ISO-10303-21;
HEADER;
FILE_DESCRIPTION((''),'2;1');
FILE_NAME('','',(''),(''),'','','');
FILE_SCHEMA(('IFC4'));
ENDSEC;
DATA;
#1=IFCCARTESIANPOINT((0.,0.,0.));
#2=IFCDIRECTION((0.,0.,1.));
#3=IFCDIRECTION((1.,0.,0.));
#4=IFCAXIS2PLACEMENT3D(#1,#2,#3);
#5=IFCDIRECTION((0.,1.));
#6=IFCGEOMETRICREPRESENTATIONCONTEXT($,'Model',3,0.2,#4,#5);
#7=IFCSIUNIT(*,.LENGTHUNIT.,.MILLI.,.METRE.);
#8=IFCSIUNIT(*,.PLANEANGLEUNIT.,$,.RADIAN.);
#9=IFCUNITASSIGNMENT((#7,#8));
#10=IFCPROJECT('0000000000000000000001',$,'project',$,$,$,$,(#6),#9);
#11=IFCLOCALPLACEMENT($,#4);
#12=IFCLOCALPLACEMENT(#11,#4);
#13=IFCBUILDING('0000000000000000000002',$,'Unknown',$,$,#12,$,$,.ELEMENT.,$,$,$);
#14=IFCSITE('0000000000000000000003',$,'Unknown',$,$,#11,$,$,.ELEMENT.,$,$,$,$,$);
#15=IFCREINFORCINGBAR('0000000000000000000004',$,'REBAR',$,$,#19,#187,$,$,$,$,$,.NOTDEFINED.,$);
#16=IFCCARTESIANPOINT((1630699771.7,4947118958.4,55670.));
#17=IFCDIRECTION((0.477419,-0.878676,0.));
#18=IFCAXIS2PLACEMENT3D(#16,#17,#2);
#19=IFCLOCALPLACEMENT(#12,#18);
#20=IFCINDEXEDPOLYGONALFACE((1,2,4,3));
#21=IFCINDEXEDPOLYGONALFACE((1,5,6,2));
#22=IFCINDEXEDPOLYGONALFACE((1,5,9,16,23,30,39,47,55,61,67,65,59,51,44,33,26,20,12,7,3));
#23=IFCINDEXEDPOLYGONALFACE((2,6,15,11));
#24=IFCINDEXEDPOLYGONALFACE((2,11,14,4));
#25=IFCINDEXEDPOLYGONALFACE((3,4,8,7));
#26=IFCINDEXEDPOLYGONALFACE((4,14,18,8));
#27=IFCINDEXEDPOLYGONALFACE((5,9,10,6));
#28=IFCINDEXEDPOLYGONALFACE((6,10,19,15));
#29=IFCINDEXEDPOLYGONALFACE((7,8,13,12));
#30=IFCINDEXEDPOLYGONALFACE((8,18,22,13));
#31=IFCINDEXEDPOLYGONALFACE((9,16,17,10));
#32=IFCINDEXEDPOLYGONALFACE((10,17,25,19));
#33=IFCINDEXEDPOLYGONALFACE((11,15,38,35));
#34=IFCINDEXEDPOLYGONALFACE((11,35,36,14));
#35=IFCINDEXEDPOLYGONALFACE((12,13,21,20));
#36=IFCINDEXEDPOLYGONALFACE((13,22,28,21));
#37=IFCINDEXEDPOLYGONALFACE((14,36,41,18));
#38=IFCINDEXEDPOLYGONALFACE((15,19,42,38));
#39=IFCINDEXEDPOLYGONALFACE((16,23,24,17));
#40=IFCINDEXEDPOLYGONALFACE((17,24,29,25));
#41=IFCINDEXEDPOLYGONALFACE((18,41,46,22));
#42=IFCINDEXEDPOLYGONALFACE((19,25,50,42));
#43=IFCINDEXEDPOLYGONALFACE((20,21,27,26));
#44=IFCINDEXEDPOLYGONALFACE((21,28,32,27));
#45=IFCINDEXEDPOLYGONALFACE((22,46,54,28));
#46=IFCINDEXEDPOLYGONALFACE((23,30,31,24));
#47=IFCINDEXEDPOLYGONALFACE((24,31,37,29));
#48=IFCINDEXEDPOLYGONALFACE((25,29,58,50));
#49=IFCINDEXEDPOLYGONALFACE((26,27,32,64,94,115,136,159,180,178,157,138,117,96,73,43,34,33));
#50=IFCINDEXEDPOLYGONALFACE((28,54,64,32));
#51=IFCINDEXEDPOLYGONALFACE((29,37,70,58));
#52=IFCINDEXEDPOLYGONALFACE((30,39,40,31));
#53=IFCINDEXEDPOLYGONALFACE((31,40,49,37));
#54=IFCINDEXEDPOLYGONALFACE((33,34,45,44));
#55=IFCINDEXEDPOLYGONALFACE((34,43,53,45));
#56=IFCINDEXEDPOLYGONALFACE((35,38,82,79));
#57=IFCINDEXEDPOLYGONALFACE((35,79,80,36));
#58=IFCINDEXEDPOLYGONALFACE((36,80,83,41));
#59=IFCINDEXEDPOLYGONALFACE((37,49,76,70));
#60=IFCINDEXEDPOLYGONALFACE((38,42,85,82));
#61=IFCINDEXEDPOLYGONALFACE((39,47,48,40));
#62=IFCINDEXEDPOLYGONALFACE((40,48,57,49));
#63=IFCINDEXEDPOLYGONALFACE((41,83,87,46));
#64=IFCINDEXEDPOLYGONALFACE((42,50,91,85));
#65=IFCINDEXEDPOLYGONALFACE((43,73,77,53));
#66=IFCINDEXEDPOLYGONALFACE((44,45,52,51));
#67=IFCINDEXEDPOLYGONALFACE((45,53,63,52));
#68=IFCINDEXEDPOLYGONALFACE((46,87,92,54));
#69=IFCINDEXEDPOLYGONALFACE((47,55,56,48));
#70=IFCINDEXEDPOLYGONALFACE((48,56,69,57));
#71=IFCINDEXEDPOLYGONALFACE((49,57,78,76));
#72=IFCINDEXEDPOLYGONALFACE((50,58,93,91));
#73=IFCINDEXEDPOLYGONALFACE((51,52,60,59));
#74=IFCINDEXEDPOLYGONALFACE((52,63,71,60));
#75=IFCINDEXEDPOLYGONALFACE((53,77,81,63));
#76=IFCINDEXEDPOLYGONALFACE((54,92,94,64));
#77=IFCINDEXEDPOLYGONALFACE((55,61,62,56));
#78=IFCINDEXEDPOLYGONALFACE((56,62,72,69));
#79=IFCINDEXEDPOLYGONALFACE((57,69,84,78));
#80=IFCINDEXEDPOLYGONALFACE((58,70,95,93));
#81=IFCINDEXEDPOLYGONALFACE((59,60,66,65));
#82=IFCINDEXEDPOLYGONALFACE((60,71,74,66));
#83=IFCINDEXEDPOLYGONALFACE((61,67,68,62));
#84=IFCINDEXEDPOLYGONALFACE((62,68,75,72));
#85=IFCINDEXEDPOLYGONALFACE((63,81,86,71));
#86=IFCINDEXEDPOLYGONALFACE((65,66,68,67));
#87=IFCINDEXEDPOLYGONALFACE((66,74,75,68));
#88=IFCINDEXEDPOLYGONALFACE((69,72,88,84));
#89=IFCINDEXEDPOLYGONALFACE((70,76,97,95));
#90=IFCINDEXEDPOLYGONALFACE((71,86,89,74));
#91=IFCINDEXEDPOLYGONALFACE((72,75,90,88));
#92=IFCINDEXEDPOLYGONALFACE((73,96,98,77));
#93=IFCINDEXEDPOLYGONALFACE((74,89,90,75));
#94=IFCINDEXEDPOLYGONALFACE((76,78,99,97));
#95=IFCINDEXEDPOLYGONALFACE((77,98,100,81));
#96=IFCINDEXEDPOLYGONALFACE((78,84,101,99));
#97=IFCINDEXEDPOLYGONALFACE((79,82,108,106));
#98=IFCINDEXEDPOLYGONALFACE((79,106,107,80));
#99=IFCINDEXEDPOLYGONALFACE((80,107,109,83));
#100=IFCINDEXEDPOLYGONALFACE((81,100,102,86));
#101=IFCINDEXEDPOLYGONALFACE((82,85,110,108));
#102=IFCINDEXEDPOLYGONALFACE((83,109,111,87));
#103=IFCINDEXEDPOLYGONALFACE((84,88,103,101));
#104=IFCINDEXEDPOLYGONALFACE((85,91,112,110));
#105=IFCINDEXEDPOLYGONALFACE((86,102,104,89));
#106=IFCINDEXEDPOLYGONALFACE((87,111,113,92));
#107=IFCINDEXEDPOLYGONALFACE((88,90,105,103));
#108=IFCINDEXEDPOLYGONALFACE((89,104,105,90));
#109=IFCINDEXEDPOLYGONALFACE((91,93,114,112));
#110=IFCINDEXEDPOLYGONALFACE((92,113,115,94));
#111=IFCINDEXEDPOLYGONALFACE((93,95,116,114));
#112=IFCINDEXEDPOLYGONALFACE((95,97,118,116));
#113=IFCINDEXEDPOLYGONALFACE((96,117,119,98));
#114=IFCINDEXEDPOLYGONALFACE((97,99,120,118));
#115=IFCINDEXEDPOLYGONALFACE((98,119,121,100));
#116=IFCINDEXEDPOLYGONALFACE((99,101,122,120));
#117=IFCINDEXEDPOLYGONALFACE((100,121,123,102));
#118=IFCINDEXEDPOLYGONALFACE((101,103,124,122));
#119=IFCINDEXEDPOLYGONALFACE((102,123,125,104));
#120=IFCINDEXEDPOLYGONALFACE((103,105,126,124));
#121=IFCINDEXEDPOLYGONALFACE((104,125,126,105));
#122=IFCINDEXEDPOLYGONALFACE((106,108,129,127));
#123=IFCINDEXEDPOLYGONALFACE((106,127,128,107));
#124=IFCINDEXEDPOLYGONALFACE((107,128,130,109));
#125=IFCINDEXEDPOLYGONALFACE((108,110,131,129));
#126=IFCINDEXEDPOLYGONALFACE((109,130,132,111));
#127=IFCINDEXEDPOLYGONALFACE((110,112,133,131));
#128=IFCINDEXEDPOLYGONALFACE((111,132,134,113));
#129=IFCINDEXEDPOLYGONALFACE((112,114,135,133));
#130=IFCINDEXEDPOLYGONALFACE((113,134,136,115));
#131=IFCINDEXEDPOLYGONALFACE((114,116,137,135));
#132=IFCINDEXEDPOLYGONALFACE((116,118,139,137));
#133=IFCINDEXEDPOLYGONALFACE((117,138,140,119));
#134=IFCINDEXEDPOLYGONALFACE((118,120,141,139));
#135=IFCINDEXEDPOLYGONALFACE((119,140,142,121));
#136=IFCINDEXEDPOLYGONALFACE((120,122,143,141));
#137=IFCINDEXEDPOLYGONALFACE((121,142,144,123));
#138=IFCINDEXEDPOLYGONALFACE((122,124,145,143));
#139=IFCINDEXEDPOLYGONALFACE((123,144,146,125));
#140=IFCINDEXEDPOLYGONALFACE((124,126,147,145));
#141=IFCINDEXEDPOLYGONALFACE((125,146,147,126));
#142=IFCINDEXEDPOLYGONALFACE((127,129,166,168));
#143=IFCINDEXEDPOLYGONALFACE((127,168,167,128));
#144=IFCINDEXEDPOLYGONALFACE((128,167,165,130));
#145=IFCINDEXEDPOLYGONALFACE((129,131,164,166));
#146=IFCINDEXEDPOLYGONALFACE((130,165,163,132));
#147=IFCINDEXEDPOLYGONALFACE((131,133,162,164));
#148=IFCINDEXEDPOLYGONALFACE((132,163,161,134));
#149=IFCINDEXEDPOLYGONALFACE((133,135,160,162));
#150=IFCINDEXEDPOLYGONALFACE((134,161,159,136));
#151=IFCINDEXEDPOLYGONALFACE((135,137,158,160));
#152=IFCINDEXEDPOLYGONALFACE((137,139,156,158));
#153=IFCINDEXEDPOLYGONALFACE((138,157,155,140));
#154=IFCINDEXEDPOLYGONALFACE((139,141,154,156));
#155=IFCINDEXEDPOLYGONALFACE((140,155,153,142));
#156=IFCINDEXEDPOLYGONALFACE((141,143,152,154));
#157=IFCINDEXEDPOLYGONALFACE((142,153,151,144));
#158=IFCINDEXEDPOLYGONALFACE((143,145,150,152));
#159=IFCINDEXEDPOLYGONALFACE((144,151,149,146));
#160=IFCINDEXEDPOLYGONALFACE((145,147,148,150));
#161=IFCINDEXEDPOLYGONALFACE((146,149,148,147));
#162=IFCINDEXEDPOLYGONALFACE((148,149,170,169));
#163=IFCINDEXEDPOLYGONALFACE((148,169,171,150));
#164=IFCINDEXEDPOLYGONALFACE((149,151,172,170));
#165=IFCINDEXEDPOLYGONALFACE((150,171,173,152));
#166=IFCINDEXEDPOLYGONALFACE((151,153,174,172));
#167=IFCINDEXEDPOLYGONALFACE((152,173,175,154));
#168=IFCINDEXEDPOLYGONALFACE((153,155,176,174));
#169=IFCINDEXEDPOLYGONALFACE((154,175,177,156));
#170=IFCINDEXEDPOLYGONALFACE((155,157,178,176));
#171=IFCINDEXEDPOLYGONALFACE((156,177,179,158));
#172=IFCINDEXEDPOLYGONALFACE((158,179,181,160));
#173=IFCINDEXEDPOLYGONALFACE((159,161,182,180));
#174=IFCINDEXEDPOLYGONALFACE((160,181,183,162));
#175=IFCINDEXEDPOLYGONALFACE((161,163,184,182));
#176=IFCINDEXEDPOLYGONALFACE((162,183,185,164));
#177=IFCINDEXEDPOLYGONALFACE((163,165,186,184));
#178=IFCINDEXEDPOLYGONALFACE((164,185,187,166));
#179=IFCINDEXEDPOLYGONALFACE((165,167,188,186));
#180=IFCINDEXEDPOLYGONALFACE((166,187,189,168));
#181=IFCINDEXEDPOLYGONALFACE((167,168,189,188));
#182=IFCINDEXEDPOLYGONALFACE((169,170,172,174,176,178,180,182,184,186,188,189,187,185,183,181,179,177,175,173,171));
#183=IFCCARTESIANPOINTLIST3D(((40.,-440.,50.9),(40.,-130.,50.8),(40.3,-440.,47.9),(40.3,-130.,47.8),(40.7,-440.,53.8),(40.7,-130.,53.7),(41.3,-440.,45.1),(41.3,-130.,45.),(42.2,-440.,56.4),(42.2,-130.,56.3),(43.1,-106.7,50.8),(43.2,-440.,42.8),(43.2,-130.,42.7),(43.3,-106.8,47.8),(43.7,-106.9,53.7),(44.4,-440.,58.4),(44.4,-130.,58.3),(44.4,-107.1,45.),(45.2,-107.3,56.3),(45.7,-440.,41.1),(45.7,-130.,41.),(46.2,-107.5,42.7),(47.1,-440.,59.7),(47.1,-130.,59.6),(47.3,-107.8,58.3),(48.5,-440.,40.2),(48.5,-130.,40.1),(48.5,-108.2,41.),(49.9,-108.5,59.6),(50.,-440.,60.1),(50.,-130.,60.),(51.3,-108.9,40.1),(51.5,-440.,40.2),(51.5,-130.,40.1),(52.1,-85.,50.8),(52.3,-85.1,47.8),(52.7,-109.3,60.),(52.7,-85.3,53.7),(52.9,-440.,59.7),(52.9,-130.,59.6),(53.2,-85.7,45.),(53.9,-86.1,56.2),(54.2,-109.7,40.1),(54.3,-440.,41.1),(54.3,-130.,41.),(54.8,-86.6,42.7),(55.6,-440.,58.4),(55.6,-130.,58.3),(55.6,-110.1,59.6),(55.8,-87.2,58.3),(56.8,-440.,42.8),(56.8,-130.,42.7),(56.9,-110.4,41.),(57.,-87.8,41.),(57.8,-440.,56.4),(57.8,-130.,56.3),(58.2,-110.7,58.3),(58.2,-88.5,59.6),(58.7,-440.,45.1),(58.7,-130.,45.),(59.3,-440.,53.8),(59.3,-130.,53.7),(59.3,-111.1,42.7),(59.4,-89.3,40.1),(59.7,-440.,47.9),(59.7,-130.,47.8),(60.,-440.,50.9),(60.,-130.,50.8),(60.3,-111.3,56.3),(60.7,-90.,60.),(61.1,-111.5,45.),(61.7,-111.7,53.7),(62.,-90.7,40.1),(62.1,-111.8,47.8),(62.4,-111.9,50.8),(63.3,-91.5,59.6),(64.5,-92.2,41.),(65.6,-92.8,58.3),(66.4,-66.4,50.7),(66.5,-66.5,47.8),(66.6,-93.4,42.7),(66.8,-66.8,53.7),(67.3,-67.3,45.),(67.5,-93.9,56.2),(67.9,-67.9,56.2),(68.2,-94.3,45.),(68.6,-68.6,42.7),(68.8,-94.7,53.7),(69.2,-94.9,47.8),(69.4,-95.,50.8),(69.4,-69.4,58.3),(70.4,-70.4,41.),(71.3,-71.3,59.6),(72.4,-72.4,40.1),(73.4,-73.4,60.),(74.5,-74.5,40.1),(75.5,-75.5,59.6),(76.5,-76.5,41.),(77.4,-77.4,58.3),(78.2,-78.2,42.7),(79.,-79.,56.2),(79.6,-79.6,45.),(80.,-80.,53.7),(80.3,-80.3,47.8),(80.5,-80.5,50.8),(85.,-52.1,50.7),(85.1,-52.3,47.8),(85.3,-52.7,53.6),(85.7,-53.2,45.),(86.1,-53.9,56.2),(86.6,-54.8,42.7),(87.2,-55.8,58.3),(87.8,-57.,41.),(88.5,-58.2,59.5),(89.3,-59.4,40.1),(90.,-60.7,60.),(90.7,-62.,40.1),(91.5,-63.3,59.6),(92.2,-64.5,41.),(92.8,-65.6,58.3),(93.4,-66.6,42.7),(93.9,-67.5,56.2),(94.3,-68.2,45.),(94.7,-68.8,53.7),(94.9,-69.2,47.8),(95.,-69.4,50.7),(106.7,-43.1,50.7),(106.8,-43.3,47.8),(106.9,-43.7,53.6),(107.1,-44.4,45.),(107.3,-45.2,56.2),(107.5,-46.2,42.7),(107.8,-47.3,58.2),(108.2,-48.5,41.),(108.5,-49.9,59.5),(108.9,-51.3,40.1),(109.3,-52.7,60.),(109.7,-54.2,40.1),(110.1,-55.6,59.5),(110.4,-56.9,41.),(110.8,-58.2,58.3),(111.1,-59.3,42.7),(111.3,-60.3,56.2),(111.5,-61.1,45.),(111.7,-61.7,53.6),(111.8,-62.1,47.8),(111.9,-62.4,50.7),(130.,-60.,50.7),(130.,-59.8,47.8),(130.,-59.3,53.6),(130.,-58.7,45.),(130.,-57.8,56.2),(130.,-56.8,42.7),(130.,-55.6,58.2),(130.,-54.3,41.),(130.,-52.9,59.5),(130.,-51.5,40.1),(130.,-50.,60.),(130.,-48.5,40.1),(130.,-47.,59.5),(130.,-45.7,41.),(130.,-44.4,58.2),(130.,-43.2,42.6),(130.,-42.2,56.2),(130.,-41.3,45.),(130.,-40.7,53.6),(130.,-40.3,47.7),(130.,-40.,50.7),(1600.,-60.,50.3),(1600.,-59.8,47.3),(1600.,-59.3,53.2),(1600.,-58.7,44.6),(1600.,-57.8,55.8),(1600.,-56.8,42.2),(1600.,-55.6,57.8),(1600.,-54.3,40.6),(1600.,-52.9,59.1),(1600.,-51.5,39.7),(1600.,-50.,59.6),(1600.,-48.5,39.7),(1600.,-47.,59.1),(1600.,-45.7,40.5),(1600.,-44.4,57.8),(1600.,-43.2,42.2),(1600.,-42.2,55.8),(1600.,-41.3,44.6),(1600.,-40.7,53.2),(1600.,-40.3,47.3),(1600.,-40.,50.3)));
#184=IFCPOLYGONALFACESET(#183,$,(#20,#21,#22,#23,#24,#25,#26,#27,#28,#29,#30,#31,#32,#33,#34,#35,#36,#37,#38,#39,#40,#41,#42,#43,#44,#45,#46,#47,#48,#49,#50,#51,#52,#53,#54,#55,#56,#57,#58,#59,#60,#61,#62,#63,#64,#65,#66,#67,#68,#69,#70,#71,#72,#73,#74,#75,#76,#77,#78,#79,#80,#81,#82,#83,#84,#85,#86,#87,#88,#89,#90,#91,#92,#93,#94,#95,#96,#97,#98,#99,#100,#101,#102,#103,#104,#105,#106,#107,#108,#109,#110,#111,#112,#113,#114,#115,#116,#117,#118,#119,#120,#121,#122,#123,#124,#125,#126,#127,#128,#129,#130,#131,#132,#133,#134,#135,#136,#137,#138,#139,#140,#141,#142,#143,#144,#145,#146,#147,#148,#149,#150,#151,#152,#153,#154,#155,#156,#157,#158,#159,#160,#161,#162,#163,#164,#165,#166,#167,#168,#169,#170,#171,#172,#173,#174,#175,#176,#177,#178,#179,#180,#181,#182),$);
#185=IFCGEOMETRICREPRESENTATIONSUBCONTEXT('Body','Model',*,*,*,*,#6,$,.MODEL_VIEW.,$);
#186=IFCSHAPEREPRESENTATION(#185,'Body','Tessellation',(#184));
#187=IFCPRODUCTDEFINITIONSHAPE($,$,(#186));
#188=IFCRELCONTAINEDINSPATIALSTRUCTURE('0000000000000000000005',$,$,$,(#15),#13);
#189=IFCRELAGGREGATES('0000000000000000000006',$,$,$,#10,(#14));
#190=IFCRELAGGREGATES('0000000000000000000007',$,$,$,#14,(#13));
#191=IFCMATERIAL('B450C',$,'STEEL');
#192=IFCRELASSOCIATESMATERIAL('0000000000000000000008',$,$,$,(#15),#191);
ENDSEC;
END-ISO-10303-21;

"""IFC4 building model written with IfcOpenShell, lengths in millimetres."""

from ifc_helpers import new_model, entity, si_unit, direction, frame, origin_with_axes, place, context, subcontext, project, spatial, material, element, save


model = new_model("IFC4")

# Units and contexts
model_context = context("Model", 3, precision=0.2, world=origin_with_axes(), true_north=direction((0.0, 1.0)))
body_context = subcontext(model_context, "Body", "Model", "MODEL_VIEW")
ifc_project = project(units=[si_unit("LENGTHUNIT", "METRE", prefix="MILLI"), si_unit("PLANEANGLEUNIT", "RADIAN")], contexts=[model_context])

# Site, building
site_placement = place(None, origin_with_axes())
site = spatial("IfcSite", under=ifc_project, at=site_placement, Name="Unknown", CompositionType="ELEMENT")
building_placement = place(site_placement, origin_with_axes())
building = spatial("IfcBuilding", under=site, at=building_placement, Name="Unknown", CompositionType="ELEMENT")

# Reinforcing bar
ifc_material = material(Name="B450C", Category="STEEL")
reinforcing_bar_1_placement = place(building_placement, frame((1630699771.7, 4947118958.4, 55670.0), z_axis=(0.477419, -0.878676, 0.0), x_axis=(0.0, 0.0, 1.0)))
element("IfcReinforcingBar", 1, at=reinforcing_bar_1_placement, inside=building, material=ifc_material, Name="REBAR", PredefinedType="NOTDEFINED", context=body_context, shape_type="AdvancedSweptSolid", body=[
    entity("IfcSweptDiskSolid", entity("IfcIndexedPolyCurve", entity("IfcCartesianPointList3D", [[50.0, -440.0, 50.1], [50.0, -130.0, 50.0], [73.4, -73.4, 50.0], [130.0, -50.0, 50.0], [1600.0, -50.0, 49.6]]), [entity("IfcLineIndex", [1, 2]), entity("IfcArcIndex", [2, 3, 4]), entity("IfcLineIndex", [4, 5])]), 10.0),
])

save(model, "model.ifc")
